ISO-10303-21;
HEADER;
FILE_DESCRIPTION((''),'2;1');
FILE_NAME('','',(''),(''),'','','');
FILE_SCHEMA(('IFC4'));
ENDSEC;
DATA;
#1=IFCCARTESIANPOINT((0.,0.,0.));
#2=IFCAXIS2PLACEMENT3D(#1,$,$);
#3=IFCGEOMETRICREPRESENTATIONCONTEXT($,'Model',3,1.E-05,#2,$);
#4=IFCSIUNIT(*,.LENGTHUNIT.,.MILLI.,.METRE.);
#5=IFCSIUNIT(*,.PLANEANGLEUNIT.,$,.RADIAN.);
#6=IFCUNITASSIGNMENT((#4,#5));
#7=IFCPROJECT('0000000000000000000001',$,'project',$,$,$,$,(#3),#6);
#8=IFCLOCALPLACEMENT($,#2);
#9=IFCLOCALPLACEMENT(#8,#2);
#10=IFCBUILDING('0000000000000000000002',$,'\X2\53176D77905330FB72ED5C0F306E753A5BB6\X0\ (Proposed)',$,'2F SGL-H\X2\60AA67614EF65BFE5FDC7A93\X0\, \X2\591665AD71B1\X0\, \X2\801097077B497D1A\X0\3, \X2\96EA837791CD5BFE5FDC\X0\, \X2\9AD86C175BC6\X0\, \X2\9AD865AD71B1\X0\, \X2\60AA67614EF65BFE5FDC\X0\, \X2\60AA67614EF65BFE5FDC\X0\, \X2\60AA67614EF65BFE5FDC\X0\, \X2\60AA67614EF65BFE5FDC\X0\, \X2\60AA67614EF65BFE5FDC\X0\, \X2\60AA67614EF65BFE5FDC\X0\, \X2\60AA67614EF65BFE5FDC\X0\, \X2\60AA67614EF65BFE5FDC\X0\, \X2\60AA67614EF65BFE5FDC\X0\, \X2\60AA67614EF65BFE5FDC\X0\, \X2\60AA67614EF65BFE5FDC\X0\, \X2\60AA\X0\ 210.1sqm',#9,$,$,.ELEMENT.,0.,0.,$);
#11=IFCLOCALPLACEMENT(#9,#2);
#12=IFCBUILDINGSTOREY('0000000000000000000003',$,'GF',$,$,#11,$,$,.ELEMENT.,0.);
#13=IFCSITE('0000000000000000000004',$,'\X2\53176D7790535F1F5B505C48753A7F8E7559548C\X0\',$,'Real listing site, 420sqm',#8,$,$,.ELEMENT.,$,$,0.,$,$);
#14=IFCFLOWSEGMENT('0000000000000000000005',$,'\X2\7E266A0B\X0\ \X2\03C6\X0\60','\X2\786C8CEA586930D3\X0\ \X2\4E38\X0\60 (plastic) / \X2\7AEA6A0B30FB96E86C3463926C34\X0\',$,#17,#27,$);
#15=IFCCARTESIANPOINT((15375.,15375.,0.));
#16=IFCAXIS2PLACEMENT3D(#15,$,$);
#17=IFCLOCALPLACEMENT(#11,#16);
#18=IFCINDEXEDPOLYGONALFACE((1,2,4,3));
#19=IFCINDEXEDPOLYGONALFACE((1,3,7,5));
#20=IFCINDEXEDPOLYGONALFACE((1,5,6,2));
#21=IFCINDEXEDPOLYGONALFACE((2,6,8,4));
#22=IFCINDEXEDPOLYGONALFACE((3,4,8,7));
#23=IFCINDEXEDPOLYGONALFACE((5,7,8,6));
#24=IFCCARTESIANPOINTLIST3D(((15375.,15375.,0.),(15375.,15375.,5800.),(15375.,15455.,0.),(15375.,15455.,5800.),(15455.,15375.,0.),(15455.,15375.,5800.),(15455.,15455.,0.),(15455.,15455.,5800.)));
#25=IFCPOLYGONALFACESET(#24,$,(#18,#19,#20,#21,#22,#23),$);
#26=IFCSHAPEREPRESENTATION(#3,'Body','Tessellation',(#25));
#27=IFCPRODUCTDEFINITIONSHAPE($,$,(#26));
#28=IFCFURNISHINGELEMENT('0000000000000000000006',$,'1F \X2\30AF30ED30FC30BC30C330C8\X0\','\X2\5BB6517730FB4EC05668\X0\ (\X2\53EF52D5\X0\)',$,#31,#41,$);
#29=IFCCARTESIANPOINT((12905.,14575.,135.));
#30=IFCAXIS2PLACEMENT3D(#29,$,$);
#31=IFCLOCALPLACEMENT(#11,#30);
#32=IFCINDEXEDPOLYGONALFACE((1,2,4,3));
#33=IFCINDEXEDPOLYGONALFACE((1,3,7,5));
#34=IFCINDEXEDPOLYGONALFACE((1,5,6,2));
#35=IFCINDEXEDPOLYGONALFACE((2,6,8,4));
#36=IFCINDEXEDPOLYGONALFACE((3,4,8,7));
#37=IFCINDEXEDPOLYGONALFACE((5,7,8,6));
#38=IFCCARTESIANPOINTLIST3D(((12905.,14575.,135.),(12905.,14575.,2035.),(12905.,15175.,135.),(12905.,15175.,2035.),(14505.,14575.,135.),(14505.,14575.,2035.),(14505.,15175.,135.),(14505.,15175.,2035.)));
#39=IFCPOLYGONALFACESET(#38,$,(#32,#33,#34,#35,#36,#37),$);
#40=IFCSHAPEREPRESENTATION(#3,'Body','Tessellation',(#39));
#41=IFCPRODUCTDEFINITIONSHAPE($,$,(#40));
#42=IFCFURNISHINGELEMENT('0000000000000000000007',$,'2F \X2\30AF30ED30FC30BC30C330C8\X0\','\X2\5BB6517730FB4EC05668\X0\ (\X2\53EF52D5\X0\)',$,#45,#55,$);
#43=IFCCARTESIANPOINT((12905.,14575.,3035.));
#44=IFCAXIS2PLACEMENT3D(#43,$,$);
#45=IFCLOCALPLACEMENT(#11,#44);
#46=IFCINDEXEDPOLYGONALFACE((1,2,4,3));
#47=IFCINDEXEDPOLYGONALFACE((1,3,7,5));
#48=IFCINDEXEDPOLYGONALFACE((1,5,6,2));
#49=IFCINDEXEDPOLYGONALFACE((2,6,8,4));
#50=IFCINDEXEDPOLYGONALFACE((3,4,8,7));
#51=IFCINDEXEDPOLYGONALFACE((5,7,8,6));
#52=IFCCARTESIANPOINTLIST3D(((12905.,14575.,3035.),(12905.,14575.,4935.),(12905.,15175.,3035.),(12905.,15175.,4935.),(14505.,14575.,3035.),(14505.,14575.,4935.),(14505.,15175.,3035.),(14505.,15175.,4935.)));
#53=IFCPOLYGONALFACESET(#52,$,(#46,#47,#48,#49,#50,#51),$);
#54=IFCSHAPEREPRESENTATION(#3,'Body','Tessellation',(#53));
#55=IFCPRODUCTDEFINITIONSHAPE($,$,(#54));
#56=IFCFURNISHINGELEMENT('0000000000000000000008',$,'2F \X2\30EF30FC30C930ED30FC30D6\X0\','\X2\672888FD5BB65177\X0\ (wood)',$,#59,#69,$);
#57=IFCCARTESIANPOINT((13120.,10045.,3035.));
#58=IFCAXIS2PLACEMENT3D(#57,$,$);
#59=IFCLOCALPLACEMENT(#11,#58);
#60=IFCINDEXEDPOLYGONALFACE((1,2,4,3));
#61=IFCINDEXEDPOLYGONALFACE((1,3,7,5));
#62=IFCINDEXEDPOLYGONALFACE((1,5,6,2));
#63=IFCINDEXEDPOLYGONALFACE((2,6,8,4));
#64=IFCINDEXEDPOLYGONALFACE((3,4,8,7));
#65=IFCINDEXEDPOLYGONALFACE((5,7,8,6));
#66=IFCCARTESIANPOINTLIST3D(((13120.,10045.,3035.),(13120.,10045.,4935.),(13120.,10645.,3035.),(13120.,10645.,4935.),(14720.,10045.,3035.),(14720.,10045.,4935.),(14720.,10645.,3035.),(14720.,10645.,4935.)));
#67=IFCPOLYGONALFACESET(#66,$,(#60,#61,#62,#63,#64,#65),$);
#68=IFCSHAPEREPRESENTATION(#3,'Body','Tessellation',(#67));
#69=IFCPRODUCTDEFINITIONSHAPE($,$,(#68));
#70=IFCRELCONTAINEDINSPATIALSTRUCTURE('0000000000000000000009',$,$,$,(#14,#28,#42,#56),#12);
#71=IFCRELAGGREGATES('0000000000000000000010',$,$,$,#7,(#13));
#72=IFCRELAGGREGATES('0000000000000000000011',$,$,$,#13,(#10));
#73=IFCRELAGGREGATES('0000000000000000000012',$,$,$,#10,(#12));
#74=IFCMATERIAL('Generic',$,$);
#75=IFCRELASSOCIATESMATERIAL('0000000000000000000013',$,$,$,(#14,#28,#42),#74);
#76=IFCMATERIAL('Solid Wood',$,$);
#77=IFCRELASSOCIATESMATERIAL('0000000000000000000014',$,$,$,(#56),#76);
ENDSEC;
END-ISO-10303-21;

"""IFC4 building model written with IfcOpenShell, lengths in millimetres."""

from ifc_helpers import new_model, si_unit, frame, frame_2d, origin, place, context, project, spatial, rectangle, extrude, material, element, save


model = new_model("IFC4")

# Units and contexts
model_context = context("Model", 3, precision=1e-05, world=origin())
ifc_project = project(units=[si_unit("LENGTHUNIT", "METRE", prefix="MILLI"), si_unit("PLANEANGLEUNIT", "RADIAN")], contexts=[model_context])

# Site, building, storey
site_placement = place(None, origin())
site = spatial("IfcSite", under=ifc_project, at=site_placement, Name="北海道弟子屈町美留和", ObjectType="Real listing site, 420sqm", CompositionType="ELEMENT", RefElevation=0.0)
building_placement = place(site_placement, origin())
building = spatial("IfcBuilding", under=site, at=building_placement, Name="北海道・狭小の町家 (Proposed)", ObjectType="2F SGL-H悪条件対応窓, 外断熱, 耐震等級3, 雪荷重対応, 高気密, 高断熱, 悪条件対応, 悪条件対応, 悪条件対応, 悪条件対応, 悪条件対応, 悪条件対応, 悪条件対応, 悪条件対応, 悪条件対応, 悪条件対応, 悪条件対応, 悪 210.1sqm", CompositionType="ELEMENT", ElevationOfRefHeight=0.0, ElevationOfTerrain=0.0)
storey_placement = place(building_placement, origin())
storey = spatial("IfcBuildingStorey", under=building, at=storey_placement, Name="GF", CompositionType="ELEMENT", Elevation=0.0)

# Shared definitions
ifc_material_1 = material(Name="Solid Wood")

# Shared definitions
ifc_material_2 = material(Name="Generic")

# Flow segment
flow_segment_placement = place(storey_placement, frame((15375.0, 15375.0, 0.0)))
element("IfcFlowSegment", 1, at=flow_segment_placement, inside=storey, material=ifc_material_2, Name="縦樋 φ60", Description="硬質塩ビ 丸60 (plastic) / 竪樋・雨水排水", context=model_context, shape_type="SweptSolid", body=[
    extrude(rectangle(XDim=80.0, YDim=80.0, at=frame_2d((40.0, 40.0))), frame((15375.0, 15375.0, 0.0)), (0.0, 0.0, 1.0), 5800.0),
])

# Furnishing elements
furnishing_1_placement = place(storey_placement, frame((12905.0, 14575.0, 135.0)))
element("IfcFurnishingElement", 2, at=furnishing_1_placement, inside=storey, material=ifc_material_2, Name="1F クローゼット", Description="家具・什器 (可動)", context=model_context, shape_type="SweptSolid", body=[
    extrude(rectangle(XDim=1600.0, YDim=600.0, at=frame_2d((800.0, 300.0))), frame((12905.0, 14575.0, 135.0)), (0.0, 0.0, 1.0), 1900.0),
])
furnishing_2_placement = place(storey_placement, frame((12905.0, 14575.0, 3035.0)))
element("IfcFurnishingElement", 3, at=furnishing_2_placement, inside=storey, material=ifc_material_2, Name="2F クローゼット", Description="家具・什器 (可動)", context=model_context, shape_type="SweptSolid", body=[
    extrude(rectangle(XDim=1600.0, YDim=600.0, at=frame_2d((800.0, 300.0))), frame((12905.0, 14575.0, 3035.0)), (0.0, 0.0, 1.0), 1900.0),
])
furnishing_3_placement = place(storey_placement, frame((13120.0, 10045.0, 3035.0)))
element("IfcFurnishingElement", 4, at=furnishing_3_placement, inside=storey, material=ifc_material_1, Name="2F ワードローブ", Description="木製家具 (wood)", context=model_context, shape_type="SweptSolid", body=[
    extrude(rectangle(XDim=1600.0, YDim=600.0, at=frame_2d((800.0, 300.0))), frame((13120.0, 10045.0, 3035.0)), (0.0, 0.0, 1.0), 1900.0),
])

save(model, "model.ifc")
